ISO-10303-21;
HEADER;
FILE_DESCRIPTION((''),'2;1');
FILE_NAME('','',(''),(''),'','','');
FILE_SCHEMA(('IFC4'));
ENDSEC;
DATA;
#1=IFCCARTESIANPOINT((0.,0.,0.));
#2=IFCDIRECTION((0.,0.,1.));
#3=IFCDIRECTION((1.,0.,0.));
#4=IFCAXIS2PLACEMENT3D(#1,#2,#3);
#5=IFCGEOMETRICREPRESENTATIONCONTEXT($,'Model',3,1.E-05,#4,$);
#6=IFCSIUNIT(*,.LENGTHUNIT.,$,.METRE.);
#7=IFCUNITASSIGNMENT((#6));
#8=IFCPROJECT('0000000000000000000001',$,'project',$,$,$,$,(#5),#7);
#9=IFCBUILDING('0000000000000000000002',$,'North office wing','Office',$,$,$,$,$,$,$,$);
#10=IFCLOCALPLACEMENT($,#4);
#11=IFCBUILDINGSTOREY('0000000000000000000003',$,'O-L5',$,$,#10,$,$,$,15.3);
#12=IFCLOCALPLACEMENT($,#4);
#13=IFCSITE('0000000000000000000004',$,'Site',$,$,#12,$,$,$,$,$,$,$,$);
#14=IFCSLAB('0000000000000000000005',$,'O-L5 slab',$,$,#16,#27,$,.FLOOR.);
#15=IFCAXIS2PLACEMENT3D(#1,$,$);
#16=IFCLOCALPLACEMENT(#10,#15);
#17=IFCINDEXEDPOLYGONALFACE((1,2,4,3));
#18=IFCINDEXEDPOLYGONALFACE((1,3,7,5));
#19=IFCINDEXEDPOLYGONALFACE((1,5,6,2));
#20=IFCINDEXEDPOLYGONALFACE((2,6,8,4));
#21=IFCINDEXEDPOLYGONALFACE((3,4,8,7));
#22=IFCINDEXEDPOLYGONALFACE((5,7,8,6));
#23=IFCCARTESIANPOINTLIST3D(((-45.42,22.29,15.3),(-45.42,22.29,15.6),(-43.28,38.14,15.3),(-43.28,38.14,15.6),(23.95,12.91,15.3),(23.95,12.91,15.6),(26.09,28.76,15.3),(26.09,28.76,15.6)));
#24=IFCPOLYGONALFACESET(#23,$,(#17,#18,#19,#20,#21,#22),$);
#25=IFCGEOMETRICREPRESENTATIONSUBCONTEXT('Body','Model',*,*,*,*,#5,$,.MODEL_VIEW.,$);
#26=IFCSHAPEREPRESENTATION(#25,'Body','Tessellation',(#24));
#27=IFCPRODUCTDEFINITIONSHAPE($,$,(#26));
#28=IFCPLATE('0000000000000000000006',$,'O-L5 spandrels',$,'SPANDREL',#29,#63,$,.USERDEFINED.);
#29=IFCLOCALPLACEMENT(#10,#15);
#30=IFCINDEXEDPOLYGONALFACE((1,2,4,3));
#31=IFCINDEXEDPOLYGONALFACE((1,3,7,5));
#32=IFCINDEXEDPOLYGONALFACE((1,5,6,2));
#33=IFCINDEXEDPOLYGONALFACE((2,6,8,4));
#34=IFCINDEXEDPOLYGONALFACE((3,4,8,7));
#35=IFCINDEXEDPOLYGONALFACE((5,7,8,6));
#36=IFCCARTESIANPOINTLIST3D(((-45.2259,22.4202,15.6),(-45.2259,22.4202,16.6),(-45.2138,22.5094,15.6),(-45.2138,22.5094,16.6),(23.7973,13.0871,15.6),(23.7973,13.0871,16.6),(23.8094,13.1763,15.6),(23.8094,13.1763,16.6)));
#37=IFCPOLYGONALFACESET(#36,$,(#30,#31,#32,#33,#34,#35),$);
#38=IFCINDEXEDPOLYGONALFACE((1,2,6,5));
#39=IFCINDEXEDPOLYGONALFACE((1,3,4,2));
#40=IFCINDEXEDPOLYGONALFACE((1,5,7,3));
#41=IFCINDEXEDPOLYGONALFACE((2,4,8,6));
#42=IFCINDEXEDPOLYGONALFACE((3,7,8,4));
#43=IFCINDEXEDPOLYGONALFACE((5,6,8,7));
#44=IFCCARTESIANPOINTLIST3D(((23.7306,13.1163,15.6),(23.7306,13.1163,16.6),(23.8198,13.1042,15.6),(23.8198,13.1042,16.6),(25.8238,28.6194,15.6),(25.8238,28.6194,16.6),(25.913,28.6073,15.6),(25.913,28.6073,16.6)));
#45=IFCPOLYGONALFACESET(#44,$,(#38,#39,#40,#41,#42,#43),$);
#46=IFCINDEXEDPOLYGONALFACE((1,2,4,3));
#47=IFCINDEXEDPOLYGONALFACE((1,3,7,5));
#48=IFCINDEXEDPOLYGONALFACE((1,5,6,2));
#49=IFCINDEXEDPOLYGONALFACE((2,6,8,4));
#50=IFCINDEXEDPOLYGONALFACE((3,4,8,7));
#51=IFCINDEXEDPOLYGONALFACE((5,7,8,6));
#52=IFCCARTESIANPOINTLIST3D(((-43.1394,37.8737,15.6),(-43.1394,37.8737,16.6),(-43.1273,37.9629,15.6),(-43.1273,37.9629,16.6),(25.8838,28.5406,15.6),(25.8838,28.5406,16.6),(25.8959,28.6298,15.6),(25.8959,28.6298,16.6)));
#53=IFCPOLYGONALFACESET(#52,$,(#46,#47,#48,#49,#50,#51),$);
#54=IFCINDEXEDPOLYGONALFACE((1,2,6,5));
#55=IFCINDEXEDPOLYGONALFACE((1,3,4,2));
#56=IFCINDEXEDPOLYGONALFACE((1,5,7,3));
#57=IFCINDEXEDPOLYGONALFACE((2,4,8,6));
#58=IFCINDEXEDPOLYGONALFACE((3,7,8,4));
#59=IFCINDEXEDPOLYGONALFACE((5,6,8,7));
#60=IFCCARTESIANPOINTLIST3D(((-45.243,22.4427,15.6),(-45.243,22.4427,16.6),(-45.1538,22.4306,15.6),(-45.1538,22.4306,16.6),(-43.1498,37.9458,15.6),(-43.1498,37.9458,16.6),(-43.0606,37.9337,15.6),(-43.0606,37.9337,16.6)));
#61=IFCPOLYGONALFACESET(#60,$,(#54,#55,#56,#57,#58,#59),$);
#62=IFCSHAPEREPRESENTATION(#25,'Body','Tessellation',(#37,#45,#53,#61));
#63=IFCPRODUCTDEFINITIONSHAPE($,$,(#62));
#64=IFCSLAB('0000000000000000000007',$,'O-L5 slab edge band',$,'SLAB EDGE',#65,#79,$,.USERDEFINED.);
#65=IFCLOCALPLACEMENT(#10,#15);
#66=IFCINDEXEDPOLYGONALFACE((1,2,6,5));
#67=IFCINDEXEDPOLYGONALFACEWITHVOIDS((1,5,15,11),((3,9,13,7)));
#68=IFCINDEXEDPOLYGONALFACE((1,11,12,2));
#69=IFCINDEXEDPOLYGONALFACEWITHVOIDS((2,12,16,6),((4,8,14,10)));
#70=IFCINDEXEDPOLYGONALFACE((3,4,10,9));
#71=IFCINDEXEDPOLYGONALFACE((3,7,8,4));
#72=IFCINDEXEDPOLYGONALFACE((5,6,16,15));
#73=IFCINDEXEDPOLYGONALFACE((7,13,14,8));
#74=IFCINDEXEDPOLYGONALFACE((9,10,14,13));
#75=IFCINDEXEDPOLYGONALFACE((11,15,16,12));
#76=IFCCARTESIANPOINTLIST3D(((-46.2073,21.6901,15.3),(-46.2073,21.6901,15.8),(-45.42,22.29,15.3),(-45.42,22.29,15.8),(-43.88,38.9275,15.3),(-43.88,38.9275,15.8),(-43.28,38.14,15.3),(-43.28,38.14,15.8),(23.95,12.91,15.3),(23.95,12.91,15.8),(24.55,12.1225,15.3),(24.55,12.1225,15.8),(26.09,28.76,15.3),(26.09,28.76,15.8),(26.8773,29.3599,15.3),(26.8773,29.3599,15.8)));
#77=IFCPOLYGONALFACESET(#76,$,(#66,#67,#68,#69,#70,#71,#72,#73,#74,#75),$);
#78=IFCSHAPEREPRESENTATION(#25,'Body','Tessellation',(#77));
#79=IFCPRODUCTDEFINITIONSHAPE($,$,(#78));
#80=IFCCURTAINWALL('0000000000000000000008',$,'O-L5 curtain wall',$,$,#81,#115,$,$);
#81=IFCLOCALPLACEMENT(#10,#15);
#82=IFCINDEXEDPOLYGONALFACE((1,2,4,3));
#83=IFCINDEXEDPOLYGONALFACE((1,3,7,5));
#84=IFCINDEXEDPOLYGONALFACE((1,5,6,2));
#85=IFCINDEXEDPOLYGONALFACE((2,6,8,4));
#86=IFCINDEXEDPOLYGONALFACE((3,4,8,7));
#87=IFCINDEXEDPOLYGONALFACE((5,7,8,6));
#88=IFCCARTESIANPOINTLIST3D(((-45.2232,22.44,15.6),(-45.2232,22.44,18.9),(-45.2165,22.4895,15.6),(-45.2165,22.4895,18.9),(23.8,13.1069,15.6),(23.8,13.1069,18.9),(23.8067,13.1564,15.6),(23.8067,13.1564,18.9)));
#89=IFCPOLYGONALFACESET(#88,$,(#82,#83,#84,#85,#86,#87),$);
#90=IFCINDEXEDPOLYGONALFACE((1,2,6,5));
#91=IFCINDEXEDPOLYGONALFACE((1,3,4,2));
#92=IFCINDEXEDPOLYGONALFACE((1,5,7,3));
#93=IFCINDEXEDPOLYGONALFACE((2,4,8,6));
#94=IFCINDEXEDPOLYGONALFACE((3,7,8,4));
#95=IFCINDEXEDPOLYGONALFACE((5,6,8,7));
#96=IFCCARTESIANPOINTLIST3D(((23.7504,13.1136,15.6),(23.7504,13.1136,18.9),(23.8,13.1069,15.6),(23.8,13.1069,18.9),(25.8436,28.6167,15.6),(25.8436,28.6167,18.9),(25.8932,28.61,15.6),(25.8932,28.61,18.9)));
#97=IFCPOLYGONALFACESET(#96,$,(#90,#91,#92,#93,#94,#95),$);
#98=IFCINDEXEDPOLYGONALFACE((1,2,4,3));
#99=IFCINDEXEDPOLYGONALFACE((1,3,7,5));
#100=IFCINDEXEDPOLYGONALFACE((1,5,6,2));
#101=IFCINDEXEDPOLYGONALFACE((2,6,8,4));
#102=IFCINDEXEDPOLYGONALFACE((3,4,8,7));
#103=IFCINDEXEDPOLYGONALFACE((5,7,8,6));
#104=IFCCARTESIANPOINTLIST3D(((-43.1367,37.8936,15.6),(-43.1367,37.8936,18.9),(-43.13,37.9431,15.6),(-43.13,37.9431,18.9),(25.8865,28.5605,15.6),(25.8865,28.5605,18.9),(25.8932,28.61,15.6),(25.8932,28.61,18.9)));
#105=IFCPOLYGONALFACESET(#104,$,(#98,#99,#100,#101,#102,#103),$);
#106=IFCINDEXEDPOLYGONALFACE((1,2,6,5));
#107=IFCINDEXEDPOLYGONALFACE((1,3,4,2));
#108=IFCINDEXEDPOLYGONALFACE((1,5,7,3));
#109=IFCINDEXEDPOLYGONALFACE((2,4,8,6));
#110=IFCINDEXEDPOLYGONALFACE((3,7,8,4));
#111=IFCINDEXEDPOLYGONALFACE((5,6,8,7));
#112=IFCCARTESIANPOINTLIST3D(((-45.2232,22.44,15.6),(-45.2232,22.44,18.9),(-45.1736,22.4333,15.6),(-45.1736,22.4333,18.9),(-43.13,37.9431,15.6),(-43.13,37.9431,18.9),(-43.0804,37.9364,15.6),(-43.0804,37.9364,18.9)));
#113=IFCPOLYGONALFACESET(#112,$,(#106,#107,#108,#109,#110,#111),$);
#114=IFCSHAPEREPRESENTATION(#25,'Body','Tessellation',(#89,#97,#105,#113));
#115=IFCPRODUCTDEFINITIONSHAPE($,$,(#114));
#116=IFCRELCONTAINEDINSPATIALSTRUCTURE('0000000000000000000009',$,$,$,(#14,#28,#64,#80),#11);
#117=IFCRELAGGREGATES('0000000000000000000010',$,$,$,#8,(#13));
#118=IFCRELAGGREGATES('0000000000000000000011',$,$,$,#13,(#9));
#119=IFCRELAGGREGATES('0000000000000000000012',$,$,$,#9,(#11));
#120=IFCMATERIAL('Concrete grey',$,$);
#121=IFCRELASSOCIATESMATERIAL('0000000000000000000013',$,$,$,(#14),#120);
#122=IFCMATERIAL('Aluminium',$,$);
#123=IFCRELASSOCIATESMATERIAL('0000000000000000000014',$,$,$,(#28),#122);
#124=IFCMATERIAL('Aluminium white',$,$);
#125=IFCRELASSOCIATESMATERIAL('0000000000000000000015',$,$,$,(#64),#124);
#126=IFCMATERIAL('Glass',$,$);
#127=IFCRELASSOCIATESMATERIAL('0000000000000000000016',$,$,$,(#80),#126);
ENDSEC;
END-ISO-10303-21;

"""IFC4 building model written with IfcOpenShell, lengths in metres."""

from ifc_helpers import new_model, si_unit, frame, origin_with_axes, place, context, subcontext, project, spatial, polyline, outline, extrude, material, element, save


model = new_model("IFC4")

# Units and contexts
model_context = context("Model", 3, precision=1e-05, world=origin_with_axes())
body_context = subcontext(model_context, "Body", "Model", "MODEL_VIEW")
ifc_project = project(units=[si_unit("LENGTHUNIT", "METRE")], contexts=[model_context])

# Site, building, storey
site_placement = place(None, origin_with_axes())
site = spatial("IfcSite", under=ifc_project, at=site_placement, Name="Site")
building = spatial("IfcBuilding", under=site, Name="North office wing", Description="Office")
storey_placement = place(None, origin_with_axes())
storey = spatial("IfcBuildingStorey", under=building, at=storey_placement, Name="O-L5", Elevation=15.3)

# Shared definitions
ifc_material_1 = material(Name="Aluminium")

# Slab
ifc_material_2 = material(Name="Concrete grey")
slab_1_placement = place(storey_placement, origin_with_axes())
element("IfcSlab", 1, at=slab_1_placement, inside=storey, material=ifc_material_2, Name="O-L5 slab", PredefinedType="FLOOR", context=body_context, shape_type="SweptSolid", body=[
    extrude(outline(polyline([(-45.42, 22.29), (23.95, 12.91), (26.09, 28.76), (-43.28, 38.14), (-45.42, 22.29)])), frame((0.0, 0.0, 15.3), z_axis=(0.0, 0.0, 1.0), x_axis=(1.0, 0.0, 0.0)), (0.0, 0.0, 1.0), 0.3),
])

# Plate
plate_placement = place(storey_placement, origin_with_axes())
element("IfcPlate", 2, at=plate_placement, inside=storey, material=ifc_material_1, Name="O-L5 spandrels", ObjectType="SPANDREL", PredefinedType="USERDEFINED", context=body_context, shape_type="SweptSolid", body=[
    extrude(outline(polyline([(-45.2259, 22.4202), (23.7973, 13.0871), (23.8094, 13.1763), (-45.2138, 22.5094), (-45.2259, 22.4202)])), frame((0.0, 0.0, 15.6), z_axis=(0.0, 0.0, 1.0), x_axis=(1.0, 0.0, 0.0)), (0.0, 0.0, 1.0), 1.0),
    extrude(outline(polyline([(23.8198, 13.1042), (25.913, 28.6073), (25.8238, 28.6194), (23.7306, 13.1163), (23.8198, 13.1042)])), frame((0.0, 0.0, 15.6), z_axis=(0.0, 0.0, 1.0), x_axis=(1.0, 0.0, 0.0)), (0.0, 0.0, 1.0), 1.0),
    extrude(outline(polyline([(25.8959, 28.6298), (-43.1273, 37.9629), (-43.1394, 37.8737), (25.8838, 28.5406), (25.8959, 28.6298)])), frame((0.0, 0.0, 15.6), z_axis=(0.0, 0.0, 1.0), x_axis=(1.0, 0.0, 0.0)), (0.0, 0.0, 1.0), 1.0),
    extrude(outline(polyline([(-43.1498, 37.9458), (-45.243, 22.4427), (-45.1538, 22.4306), (-43.0606, 37.9337), (-43.1498, 37.9458)])), frame((0.0, 0.0, 15.6), z_axis=(0.0, 0.0, 1.0), x_axis=(1.0, 0.0, 0.0)), (0.0, 0.0, 1.0), 1.0),
])

# Slab
ifc_material_3 = material(Name="Aluminium white")
slab_2_placement = place(storey_placement, origin_with_axes())
element("IfcSlab", 3, at=slab_2_placement, inside=storey, material=ifc_material_3, Name="O-L5 slab edge band", ObjectType="SLAB EDGE", PredefinedType="USERDEFINED", context=body_context, shape_type="SweptSolid", body=[
    extrude(outline(polyline([(-46.2073, 21.6901), (24.55, 12.1225), (26.8773, 29.3599), (-43.88, 38.9275), (-46.2073, 21.6901)]), holes=[polyline([(-45.42, 22.29), (23.95, 12.91), (26.09, 28.76), (-43.28, 38.14), (-45.42, 22.29)])]), frame((0.0, 0.0, 15.3), z_axis=(0.0, 0.0, 1.0), x_axis=(1.0, 0.0, 0.0)), (0.0, 0.0, 1.0), 0.5),
])

# Curtain wall
ifc_material_4 = material(Name="Glass")
curtain_wall_placement = place(storey_placement, origin_with_axes())
element("IfcCurtainWall", 4, at=curtain_wall_placement, inside=storey, material=ifc_material_4, Name="O-L5 curtain wall", context=body_context, shape_type="SweptSolid", body=[
    extrude(outline(polyline([(-45.2232, 22.44), (23.8, 13.1069), (23.8067, 13.1564), (-45.2165, 22.4895), (-45.2232, 22.44)])), frame((0.0, 0.0, 15.6), z_axis=(0.0, 0.0, 1.0), x_axis=(1.0, 0.0, 0.0)), (0.0, 0.0, 1.0), 3.3),
    extrude(outline(polyline([(23.8, 13.1069), (25.8932, 28.61), (25.8436, 28.6167), (23.7504, 13.1136), (23.8, 13.1069)])), frame((0.0, 0.0, 15.6), z_axis=(0.0, 0.0, 1.0), x_axis=(1.0, 0.0, 0.0)), (0.0, 0.0, 1.0), 3.3),
    extrude(outline(polyline([(25.8932, 28.61), (-43.13, 37.9431), (-43.1367, 37.8936), (25.8865, 28.5605), (25.8932, 28.61)])), frame((0.0, 0.0, 15.6), z_axis=(0.0, 0.0, 1.0), x_axis=(1.0, 0.0, 0.0)), (0.0, 0.0, 1.0), 3.3),
    extrude(outline(polyline([(-43.13, 37.9431), (-45.2232, 22.44), (-45.1736, 22.4333), (-43.0804, 37.9364), (-43.13, 37.9431)])), frame((0.0, 0.0, 15.6), z_axis=(0.0, 0.0, 1.0), x_axis=(1.0, 0.0, 0.0)), (0.0, 0.0, 1.0), 3.3),
])

save(model, "model.ifc")
